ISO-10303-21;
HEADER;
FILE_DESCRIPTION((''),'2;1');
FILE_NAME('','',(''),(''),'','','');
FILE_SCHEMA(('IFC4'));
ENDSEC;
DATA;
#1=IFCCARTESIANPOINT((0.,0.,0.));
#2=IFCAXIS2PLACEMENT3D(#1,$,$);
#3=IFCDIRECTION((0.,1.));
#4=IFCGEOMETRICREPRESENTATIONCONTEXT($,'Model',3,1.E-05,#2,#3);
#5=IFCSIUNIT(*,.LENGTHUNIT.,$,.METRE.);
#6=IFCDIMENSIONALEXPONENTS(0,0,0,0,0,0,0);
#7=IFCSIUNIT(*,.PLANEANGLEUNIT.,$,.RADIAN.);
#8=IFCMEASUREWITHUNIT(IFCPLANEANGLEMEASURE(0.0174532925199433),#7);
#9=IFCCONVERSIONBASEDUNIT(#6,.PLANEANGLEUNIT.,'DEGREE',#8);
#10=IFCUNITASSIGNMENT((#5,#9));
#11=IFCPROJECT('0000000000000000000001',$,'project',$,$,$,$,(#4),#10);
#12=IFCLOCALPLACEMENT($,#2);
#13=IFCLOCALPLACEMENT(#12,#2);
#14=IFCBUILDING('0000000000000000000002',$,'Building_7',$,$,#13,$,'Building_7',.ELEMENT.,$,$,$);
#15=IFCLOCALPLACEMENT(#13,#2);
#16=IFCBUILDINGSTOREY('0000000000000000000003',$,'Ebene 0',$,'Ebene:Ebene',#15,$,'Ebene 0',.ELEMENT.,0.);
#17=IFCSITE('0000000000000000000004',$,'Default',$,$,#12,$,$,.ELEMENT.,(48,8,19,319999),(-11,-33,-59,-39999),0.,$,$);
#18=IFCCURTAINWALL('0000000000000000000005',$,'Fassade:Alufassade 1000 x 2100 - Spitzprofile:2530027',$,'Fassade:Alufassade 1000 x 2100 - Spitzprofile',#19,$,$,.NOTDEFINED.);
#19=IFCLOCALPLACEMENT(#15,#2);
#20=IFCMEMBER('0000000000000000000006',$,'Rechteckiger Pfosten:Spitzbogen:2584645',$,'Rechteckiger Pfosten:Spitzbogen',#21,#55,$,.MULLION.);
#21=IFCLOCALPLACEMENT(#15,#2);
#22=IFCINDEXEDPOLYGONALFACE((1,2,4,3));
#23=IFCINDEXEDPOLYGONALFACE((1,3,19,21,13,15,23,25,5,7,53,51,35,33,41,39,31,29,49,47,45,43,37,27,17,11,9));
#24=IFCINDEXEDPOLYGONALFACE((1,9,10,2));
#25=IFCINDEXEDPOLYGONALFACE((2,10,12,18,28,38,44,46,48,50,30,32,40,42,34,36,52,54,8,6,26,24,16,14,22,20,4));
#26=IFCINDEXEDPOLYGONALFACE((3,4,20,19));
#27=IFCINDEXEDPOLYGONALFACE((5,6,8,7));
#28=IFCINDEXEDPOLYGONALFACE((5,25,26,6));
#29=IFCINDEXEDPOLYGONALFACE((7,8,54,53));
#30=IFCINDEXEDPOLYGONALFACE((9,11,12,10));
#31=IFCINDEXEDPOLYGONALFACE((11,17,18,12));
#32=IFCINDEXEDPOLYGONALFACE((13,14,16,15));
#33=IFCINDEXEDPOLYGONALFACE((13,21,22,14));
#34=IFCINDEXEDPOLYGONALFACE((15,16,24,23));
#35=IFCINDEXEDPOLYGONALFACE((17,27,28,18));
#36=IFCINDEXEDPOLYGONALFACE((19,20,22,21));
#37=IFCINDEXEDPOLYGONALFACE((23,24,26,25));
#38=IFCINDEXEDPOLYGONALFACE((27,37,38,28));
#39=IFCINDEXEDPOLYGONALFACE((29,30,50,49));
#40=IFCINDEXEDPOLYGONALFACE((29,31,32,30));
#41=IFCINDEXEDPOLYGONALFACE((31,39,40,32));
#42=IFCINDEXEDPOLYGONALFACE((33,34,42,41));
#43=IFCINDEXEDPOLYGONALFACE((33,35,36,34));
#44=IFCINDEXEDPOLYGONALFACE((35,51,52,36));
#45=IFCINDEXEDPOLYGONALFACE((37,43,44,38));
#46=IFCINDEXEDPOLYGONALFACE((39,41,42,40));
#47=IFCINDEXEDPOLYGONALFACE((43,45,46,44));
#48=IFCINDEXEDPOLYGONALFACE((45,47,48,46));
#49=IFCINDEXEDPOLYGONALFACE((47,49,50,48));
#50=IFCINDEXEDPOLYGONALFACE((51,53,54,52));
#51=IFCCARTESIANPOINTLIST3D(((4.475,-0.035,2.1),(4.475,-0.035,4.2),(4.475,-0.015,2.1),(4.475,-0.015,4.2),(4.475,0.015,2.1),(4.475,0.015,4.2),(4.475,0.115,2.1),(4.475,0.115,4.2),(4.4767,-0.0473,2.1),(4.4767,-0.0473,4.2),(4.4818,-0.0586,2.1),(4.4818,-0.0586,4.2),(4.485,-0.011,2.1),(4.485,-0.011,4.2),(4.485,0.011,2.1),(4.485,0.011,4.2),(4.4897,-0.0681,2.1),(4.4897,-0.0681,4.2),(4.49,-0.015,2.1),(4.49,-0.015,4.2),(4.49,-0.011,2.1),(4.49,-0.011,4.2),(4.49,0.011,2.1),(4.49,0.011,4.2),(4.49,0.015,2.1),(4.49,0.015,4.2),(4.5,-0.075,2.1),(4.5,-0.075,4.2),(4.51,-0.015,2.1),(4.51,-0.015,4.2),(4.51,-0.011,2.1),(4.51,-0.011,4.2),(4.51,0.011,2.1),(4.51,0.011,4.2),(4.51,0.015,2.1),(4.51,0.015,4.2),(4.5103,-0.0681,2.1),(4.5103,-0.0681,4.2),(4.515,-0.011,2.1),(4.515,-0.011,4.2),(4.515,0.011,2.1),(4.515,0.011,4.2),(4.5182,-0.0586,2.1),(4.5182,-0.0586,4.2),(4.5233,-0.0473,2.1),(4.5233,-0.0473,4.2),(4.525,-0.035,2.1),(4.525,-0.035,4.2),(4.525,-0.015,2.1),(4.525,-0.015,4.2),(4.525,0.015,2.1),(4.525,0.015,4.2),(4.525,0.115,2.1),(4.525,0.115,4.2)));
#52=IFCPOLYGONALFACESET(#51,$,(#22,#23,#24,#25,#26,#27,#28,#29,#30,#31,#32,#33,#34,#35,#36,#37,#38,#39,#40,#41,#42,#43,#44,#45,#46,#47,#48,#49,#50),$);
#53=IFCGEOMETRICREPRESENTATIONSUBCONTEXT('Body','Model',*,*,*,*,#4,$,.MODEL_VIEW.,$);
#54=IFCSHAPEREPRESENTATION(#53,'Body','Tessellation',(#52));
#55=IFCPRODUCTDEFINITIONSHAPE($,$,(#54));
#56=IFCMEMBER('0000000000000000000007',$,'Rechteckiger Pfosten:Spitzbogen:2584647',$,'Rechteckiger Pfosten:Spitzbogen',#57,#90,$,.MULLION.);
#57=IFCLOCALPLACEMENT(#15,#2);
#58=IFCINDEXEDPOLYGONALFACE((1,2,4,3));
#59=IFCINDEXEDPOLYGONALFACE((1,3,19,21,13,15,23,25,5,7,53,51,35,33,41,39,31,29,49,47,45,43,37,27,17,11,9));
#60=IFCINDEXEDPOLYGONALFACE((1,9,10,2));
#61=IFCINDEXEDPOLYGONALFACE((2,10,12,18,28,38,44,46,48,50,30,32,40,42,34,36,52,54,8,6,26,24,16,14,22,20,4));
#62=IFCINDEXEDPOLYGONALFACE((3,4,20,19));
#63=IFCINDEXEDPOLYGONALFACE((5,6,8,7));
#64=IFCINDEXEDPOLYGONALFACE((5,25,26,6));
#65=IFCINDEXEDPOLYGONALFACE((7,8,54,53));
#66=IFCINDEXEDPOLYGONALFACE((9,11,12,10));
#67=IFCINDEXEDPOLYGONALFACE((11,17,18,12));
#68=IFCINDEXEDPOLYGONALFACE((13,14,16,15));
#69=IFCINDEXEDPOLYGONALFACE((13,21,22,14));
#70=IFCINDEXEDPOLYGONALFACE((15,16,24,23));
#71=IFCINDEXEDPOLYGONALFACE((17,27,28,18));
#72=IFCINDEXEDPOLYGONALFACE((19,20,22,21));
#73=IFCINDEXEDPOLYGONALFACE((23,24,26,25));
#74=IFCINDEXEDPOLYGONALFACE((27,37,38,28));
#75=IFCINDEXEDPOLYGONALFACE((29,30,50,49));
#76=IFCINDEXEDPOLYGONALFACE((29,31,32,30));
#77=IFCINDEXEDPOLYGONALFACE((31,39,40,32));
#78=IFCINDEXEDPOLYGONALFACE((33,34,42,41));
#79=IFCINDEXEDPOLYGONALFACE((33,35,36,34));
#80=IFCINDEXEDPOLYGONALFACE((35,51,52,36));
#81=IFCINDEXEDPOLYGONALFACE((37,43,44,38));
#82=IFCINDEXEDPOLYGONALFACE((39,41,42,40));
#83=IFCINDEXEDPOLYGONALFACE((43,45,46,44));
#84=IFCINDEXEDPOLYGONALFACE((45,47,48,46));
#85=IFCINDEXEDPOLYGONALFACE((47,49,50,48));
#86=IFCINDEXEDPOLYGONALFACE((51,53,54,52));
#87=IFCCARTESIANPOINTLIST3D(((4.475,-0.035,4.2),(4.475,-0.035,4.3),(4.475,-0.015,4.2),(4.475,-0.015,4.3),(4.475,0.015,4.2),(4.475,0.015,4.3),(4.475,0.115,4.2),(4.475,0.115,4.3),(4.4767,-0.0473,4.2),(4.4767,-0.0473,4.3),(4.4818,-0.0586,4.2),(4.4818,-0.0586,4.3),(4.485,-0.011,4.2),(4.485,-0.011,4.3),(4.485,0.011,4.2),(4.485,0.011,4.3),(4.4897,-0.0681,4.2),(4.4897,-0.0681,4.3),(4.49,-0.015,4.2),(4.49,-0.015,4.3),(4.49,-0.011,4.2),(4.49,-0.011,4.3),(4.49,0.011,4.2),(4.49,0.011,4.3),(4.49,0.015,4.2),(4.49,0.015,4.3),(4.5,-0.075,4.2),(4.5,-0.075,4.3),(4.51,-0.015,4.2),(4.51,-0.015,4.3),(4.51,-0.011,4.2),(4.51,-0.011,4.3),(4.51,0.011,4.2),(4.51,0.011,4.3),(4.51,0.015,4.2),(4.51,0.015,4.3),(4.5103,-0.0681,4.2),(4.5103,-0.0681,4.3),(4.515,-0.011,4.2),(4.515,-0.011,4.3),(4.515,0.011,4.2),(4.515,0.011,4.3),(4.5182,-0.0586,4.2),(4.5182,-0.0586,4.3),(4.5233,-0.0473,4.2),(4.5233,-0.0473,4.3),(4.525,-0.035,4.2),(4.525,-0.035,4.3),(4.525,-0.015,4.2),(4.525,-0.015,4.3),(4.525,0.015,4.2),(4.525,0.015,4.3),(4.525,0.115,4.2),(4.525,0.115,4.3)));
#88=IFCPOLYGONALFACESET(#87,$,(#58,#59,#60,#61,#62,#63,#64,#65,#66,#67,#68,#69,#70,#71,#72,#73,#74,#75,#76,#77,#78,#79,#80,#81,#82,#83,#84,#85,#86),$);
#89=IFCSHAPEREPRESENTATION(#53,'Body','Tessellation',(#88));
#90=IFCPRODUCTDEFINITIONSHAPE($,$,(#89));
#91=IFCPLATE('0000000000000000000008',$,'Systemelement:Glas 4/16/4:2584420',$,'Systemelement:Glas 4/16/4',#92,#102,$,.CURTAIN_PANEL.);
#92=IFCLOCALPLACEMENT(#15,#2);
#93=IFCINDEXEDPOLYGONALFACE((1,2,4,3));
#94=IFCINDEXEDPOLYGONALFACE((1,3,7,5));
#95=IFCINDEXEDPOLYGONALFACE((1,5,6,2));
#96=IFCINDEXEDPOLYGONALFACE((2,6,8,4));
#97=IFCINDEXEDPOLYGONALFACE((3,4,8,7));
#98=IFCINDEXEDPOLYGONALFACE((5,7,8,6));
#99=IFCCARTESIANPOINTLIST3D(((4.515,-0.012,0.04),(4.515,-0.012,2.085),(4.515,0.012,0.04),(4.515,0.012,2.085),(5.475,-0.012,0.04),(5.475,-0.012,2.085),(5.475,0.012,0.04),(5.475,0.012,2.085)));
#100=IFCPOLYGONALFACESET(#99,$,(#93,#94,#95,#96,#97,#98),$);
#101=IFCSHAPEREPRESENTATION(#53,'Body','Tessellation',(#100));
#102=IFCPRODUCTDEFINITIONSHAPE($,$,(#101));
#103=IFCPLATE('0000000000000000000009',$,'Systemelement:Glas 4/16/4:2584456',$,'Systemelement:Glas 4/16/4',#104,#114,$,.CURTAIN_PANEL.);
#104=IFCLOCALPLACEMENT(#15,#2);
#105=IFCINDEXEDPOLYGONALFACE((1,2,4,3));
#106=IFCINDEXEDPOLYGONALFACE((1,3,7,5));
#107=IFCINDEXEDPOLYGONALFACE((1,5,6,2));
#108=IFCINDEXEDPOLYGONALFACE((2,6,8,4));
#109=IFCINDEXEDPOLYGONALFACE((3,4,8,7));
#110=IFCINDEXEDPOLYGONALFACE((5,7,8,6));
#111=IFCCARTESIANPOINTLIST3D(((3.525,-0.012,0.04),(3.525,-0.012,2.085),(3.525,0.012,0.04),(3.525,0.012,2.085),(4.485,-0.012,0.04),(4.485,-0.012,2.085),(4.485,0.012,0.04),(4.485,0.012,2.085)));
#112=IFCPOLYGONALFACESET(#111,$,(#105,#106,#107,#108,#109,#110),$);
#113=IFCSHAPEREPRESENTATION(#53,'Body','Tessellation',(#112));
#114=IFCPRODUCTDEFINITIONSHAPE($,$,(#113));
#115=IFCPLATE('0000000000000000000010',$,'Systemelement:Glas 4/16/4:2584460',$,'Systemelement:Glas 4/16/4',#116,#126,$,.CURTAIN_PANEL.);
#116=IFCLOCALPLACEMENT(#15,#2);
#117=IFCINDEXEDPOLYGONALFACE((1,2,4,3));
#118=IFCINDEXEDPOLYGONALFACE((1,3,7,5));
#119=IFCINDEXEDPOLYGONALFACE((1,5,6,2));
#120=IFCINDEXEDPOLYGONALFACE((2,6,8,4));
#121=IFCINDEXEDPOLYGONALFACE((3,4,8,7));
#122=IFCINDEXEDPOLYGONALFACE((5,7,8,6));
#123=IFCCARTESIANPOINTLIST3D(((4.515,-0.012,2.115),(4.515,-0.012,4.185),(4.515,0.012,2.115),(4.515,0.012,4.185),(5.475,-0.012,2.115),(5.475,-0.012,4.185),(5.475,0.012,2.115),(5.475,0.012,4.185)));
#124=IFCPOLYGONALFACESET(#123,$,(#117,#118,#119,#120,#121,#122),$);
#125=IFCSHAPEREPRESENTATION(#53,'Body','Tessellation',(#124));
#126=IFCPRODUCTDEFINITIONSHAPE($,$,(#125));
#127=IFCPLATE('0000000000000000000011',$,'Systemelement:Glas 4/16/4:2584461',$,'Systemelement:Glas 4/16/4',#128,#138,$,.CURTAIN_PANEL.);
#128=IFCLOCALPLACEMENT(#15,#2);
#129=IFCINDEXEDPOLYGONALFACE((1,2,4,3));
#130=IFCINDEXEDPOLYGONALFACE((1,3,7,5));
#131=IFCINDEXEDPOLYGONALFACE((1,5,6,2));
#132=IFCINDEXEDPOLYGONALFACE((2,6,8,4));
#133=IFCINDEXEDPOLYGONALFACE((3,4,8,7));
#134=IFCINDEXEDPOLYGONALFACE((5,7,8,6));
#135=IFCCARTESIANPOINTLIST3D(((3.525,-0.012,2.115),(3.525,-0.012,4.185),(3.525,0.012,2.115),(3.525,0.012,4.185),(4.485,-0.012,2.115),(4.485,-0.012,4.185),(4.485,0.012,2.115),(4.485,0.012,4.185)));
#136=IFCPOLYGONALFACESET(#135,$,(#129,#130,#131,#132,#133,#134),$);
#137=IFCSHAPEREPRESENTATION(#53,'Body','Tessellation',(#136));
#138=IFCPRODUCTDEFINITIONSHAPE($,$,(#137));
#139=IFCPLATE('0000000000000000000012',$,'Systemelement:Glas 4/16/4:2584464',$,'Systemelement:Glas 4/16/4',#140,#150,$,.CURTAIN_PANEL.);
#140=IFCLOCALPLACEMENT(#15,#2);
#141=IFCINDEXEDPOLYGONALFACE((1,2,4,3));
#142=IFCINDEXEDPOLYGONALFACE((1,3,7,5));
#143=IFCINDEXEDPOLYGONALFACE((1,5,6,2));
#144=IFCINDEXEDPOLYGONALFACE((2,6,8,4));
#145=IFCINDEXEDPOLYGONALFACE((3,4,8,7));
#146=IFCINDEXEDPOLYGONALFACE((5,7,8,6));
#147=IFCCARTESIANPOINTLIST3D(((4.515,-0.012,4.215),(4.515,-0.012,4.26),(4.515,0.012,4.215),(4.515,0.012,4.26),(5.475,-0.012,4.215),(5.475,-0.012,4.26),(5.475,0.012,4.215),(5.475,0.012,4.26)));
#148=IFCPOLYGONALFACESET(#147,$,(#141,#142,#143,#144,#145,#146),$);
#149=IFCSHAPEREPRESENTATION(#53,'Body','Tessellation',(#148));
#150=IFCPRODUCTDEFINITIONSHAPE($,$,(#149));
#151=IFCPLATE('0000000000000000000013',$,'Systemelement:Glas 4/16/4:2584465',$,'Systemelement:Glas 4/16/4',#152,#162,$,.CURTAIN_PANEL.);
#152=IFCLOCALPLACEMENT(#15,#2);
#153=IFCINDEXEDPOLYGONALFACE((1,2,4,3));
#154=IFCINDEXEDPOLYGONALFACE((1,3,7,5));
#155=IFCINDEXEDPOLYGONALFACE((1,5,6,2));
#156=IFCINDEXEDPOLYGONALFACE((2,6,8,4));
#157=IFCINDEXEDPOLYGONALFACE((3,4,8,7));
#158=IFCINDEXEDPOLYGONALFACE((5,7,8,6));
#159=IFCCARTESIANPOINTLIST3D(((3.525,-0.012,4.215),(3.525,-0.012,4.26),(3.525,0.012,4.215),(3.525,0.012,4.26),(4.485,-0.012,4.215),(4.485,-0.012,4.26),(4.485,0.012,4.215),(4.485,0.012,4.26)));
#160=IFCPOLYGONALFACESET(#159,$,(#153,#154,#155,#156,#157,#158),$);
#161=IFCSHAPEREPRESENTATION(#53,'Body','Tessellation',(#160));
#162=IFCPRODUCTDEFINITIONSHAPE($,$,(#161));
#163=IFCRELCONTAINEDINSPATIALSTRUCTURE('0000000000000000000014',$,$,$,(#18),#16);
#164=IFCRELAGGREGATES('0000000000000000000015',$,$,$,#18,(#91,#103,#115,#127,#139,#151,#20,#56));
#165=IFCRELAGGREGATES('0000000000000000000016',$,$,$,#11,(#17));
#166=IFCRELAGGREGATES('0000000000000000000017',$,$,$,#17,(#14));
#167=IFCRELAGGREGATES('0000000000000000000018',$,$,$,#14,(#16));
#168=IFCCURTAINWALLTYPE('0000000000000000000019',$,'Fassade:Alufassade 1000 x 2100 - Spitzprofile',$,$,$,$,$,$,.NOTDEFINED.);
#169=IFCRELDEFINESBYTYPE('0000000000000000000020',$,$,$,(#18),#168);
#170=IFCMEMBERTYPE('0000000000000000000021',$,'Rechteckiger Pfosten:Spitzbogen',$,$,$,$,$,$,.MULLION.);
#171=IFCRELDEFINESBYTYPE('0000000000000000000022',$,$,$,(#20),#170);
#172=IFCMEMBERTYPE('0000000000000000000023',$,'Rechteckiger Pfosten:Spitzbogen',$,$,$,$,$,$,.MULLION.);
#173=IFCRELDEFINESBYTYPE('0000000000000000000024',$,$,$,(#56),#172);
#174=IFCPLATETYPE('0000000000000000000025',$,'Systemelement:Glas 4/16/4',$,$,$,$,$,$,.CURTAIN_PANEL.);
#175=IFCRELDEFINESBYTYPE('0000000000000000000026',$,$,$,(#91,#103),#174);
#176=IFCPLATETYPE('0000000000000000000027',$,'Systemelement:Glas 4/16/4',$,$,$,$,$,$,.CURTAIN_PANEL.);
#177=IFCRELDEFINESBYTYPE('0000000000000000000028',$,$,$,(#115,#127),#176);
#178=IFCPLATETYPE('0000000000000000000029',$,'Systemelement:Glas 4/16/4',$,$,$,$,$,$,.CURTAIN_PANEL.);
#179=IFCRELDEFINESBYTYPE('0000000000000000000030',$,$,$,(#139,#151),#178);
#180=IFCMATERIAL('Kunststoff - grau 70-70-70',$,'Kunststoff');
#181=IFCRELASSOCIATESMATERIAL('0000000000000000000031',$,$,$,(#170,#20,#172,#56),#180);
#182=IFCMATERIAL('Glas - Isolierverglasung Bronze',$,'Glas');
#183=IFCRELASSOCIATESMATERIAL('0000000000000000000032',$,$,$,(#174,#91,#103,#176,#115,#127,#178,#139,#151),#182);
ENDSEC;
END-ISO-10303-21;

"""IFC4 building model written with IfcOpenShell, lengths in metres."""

from ifc_helpers import new_model, entity, si_unit, converted_unit, direction, frame, origin, place, context, subcontext, project, spatial, line, arc, indexed_curve, outline, extrude, source, transform, mapped, material, type_object, type_shapes, element, aggregate, save


model = new_model("IFC4")

# Units and contexts
model_context = context("Model", 3, precision=1e-05, world=origin(), true_north=direction((0.0, 1.0)))
body_context = subcontext(model_context, "Body", "Model", "MODEL_VIEW")
ifc_project = project(units=[si_unit("LENGTHUNIT", "METRE"), converted_unit("PLANEANGLEUNIT", "DEGREE", entity("IfcPlaneAngleMeasure", 0.0174532925199433), si_unit("PLANEANGLEUNIT", "RADIAN"), dimensions=[0, 0, 0, 0, 0, 0, 0])], contexts=[model_context])

# Site, building, storey
site_placement = place(None, origin())
site = spatial("IfcSite", under=ifc_project, at=site_placement, Name="Default", CompositionType="ELEMENT", RefLatitude=(48, 8, 19, 319999), RefLongitude=(-11, -33, -59, -39999), RefElevation=0.0)
building_placement = place(site_placement, origin())
building = spatial("IfcBuilding", under=site, at=building_placement, Name="Building_7", LongName="Building_7", CompositionType="ELEMENT")
storey_placement = place(building_placement, origin())
storey = spatial("IfcBuildingStorey", under=building, at=storey_placement, Name="Ebene 0", ObjectType="Ebene:Ebene", LongName="Ebene 0", CompositionType="ELEMENT", Elevation=0.0)

# Curtain wall, members, plates
curtain_wall_type = type_object("IfcCurtainWallType", Name="Fassade:Alufassade 1000 x 2100 - Spitzprofile", PredefinedType="NOTDEFINED")
curtain_wall_placement = place(storey_placement, origin())
curtain_wall = element("IfcCurtainWall", 1, at=curtain_wall_placement, inside=storey, type_object=curtain_wall_type, Name="Fassade:Alufassade 1000 x 2100 - Spitzprofile:2530027", ObjectType="Fassade:Alufassade 1000 x 2100 - Spitzprofile", PredefinedType="NOTDEFINED")
ifc_material_1 = material(Name="Kunststoff - grau 70-70-70", Category="Kunststoff")
member_type_1 = type_object("IfcMemberType", Name="Rechteckiger Pfosten:Spitzbogen", PredefinedType="MULLION", material=ifc_material_1)
shared_shape_1 = source(origin(), body_context, "Body", "SweptSolid", [
    extrude(outline(indexed_curve([(-0.111, -0.025), (-0.011, -0.025), (-0.011, -0.01), (-0.007, -0.01), (-0.007, -0.015), (0.015, -0.015), (0.015, -0.01), (0.019, -0.01), (0.019, -0.025), (0.039, -0.025), (0.0626, -0.0182), (0.079, 0.0), (0.0626, 0.0182), (0.039, 0.025), (0.019, 0.025), (0.019, 0.01), (0.015, 0.01), (0.015, 0.015), (-0.007, 0.015), (-0.007, 0.01), (-0.011, 0.01), (-0.011, 0.025), (-0.111, 0.025)], segments=[line(1, 2, 3, 4, 5, 6, 7, 8, 9, 10), arc(10, 11, 12), arc(12, 13, 14), line(14, 15, 16, 17, 18, 19, 20, 21, 22, 23, 1)], self_intersect=False)), frame((0.0, 0.004, -2.1), z_axis=(0.0, 0.0, 1.0), x_axis=(0.0, -1.0, 0.0)), (0.0, 0.0, 1.0), 2.1),
])
type_shapes(member_type_1, [shared_shape_1])
member_1_placement = place(curtain_wall_placement, frame((4.5, 0.0, 2.1), z_axis=(0.0, 0.0, -1.0), x_axis=(-1.0, 0.0, 0.0)))
member_1 = element("IfcMember", 2, at=member_1_placement, type_object=member_type_1, material=ifc_material_1, Name="Rechteckiger Pfosten:Spitzbogen:2584645", ObjectType="Rechteckiger Pfosten:Spitzbogen", PredefinedType="MULLION", context=body_context, shape_type="MappedRepresentation", body=[
    mapped(shared_shape_1, transform((0.0, 0.0, 0.0), scale=1.0)),
])
member_type_2 = type_object("IfcMemberType", Name="Rechteckiger Pfosten:Spitzbogen", PredefinedType="MULLION", material=ifc_material_1)
shared_shape_2 = source(origin(), body_context, "Body", "SweptSolid", [
    extrude(outline(indexed_curve([(-0.111, -0.025), (-0.011, -0.025), (-0.011, -0.01), (-0.007, -0.01), (-0.007, -0.015), (0.015, -0.015), (0.015, -0.01), (0.019, -0.01), (0.019, -0.025), (0.039, -0.025), (0.0626, -0.0182), (0.079, 0.0), (0.0626, 0.0182), (0.039, 0.025), (0.019, 0.025), (0.019, 0.01), (0.015, 0.01), (0.015, 0.015), (-0.007, 0.015), (-0.007, 0.01), (-0.011, 0.01), (-0.011, 0.025), (-0.111, 0.025)], segments=[line(1, 2, 3, 4, 5, 6, 7, 8, 9, 10), arc(10, 11, 12), arc(12, 13, 14), line(14, 15, 16, 17, 18, 19, 20, 21, 22, 23, 1)], self_intersect=False)), frame((0.0, 0.004, -0.1), z_axis=(0.0, 0.0, 1.0), x_axis=(0.0, -1.0, 0.0)), (0.0, 0.0, 1.0), 0.1),
])
type_shapes(member_type_2, [shared_shape_2])
member_2_placement = place(curtain_wall_placement, frame((4.5, 0.0, 4.2), z_axis=(0.0, 0.0, -1.0), x_axis=(-1.0, 0.0, 0.0)))
member_2 = element("IfcMember", 3, at=member_2_placement, type_object=member_type_2, material=ifc_material_1, Name="Rechteckiger Pfosten:Spitzbogen:2584647", ObjectType="Rechteckiger Pfosten:Spitzbogen", PredefinedType="MULLION", context=body_context, shape_type="MappedRepresentation", body=[
    mapped(shared_shape_2, transform((0.0, 0.0, 0.0), scale=1.0)),
])
ifc_material_2 = material(Name="Glas - Isolierverglasung Bronze", Category="Glas")
plate_type_1 = type_object("IfcPlateType", Name="Systemelement:Glas 4/16/4", PredefinedType="CURTAIN_PANEL", material=ifc_material_2)
shared_shape_3 = source(origin(), body_context, "Body", "SweptSolid", [
    extrude(outline(indexed_curve([(-0.012, -0.48), (0.012, -0.48), (0.012, 0.48), (-0.012, 0.48), (-0.012, -0.48)], self_intersect=False)), frame((0.0, 0.0, 0.0), z_axis=(0.0, 0.0, 1.0), x_axis=(0.0, 1.0, 0.0)), (0.0, 0.0, 1.0), 2.045),
])
type_shapes(plate_type_1, [shared_shape_3])
plate_1_placement = place(curtain_wall_placement, frame((4.995, 0.0, 0.04), z_axis=(0.0, 0.0, 1.0), x_axis=(-1.0, 0.0, 0.0)))
plate_1 = element("IfcPlate", 4, at=plate_1_placement, type_object=plate_type_1, material=ifc_material_2, Name="Systemelement:Glas 4/16/4:2584420", ObjectType="Systemelement:Glas 4/16/4", PredefinedType="CURTAIN_PANEL", context=body_context, shape_type="MappedRepresentation", body=[
    mapped(shared_shape_3, transform((0.0, 0.0, 0.0), scale=1.0)),
])
plate_2_placement = place(curtain_wall_placement, frame((4.005, 0.0, 0.04), z_axis=(0.0, 0.0, 1.0), x_axis=(-1.0, 0.0, 0.0)))
plate_2 = element("IfcPlate", 5, at=plate_2_placement, type_object=plate_type_1, material=ifc_material_2, Name="Systemelement:Glas 4/16/4:2584456", ObjectType="Systemelement:Glas 4/16/4", PredefinedType="CURTAIN_PANEL", context=body_context, shape_type="MappedRepresentation", body=[
    mapped(shared_shape_3, transform((0.0, 0.0, 0.0), scale=1.0)),
])
plate_type_2 = type_object("IfcPlateType", Name="Systemelement:Glas 4/16/4", PredefinedType="CURTAIN_PANEL", material=ifc_material_2)
shared_shape_4 = source(origin(), body_context, "Body", "SweptSolid", [
    extrude(outline(indexed_curve([(-0.012, -0.48), (0.012, -0.48), (0.012, 0.48), (-0.012, 0.48), (-0.012, -0.48)], self_intersect=False)), frame((0.0, 0.0, 0.0), z_axis=(0.0, 0.0, 1.0), x_axis=(0.0, 1.0, 0.0)), (0.0, 0.0, 1.0), 2.07),
])
type_shapes(plate_type_2, [shared_shape_4])
plate_3_placement = place(curtain_wall_placement, frame((4.995, 0.0, 2.115), z_axis=(0.0, 0.0, 1.0), x_axis=(-1.0, 0.0, 0.0)))
plate_3 = element("IfcPlate", 6, at=plate_3_placement, type_object=plate_type_2, material=ifc_material_2, Name="Systemelement:Glas 4/16/4:2584460", ObjectType="Systemelement:Glas 4/16/4", PredefinedType="CURTAIN_PANEL", context=body_context, shape_type="MappedRepresentation", body=[
    mapped(shared_shape_4, transform((0.0, 0.0, 0.0), scale=1.0)),
])
plate_4_placement = place(curtain_wall_placement, frame((4.005, 0.0, 2.115), z_axis=(0.0, 0.0, 1.0), x_axis=(-1.0, 0.0, 0.0)))
plate_4 = element("IfcPlate", 7, at=plate_4_placement, type_object=plate_type_2, material=ifc_material_2, Name="Systemelement:Glas 4/16/4:2584461", ObjectType="Systemelement:Glas 4/16/4", PredefinedType="CURTAIN_PANEL", context=body_context, shape_type="MappedRepresentation", body=[
    mapped(shared_shape_4, transform((0.0, 0.0, 0.0), scale=1.0)),
])
plate_type_3 = type_object("IfcPlateType", Name="Systemelement:Glas 4/16/4", PredefinedType="CURTAIN_PANEL", material=ifc_material_2)
shared_shape_5 = source(origin(), body_context, "Body", "SweptSolid", [
    extrude(outline(indexed_curve([(-0.012, -0.48), (0.012, -0.48), (0.012, 0.48), (-0.012, 0.48), (-0.012, -0.48)], self_intersect=False)), frame((0.0, 0.0, 0.0), z_axis=(0.0, 0.0, 1.0), x_axis=(0.0, 1.0, 0.0)), (0.0, 0.0, 1.0), 0.045),
])
type_shapes(plate_type_3, [shared_shape_5])
plate_5_placement = place(curtain_wall_placement, frame((4.995, 0.0, 4.215), z_axis=(0.0, 0.0, 1.0), x_axis=(-1.0, 0.0, 0.0)))
plate_5 = element("IfcPlate", 8, at=plate_5_placement, type_object=plate_type_3, material=ifc_material_2, Name="Systemelement:Glas 4/16/4:2584464", ObjectType="Systemelement:Glas 4/16/4", PredefinedType="CURTAIN_PANEL", context=body_context, shape_type="MappedRepresentation", body=[
    mapped(shared_shape_5, transform((0.0, 0.0, 0.0), scale=1.0)),
])
plate_6_placement = place(curtain_wall_placement, frame((4.005, 0.0, 4.215), z_axis=(0.0, 0.0, 1.0), x_axis=(-1.0, 0.0, 0.0)))
plate_6 = element("IfcPlate", 9, at=plate_6_placement, type_object=plate_type_3, material=ifc_material_2, Name="Systemelement:Glas 4/16/4:2584465", ObjectType="Systemelement:Glas 4/16/4", PredefinedType="CURTAIN_PANEL", context=body_context, shape_type="MappedRepresentation", body=[
    mapped(shared_shape_5, transform((0.0, 0.0, 0.0), scale=1.0)),
])
aggregate(curtain_wall, [plate_1, plate_2, plate_3, plate_4, plate_5, plate_6, member_1, member_2])

save(model, "model.ifc")
